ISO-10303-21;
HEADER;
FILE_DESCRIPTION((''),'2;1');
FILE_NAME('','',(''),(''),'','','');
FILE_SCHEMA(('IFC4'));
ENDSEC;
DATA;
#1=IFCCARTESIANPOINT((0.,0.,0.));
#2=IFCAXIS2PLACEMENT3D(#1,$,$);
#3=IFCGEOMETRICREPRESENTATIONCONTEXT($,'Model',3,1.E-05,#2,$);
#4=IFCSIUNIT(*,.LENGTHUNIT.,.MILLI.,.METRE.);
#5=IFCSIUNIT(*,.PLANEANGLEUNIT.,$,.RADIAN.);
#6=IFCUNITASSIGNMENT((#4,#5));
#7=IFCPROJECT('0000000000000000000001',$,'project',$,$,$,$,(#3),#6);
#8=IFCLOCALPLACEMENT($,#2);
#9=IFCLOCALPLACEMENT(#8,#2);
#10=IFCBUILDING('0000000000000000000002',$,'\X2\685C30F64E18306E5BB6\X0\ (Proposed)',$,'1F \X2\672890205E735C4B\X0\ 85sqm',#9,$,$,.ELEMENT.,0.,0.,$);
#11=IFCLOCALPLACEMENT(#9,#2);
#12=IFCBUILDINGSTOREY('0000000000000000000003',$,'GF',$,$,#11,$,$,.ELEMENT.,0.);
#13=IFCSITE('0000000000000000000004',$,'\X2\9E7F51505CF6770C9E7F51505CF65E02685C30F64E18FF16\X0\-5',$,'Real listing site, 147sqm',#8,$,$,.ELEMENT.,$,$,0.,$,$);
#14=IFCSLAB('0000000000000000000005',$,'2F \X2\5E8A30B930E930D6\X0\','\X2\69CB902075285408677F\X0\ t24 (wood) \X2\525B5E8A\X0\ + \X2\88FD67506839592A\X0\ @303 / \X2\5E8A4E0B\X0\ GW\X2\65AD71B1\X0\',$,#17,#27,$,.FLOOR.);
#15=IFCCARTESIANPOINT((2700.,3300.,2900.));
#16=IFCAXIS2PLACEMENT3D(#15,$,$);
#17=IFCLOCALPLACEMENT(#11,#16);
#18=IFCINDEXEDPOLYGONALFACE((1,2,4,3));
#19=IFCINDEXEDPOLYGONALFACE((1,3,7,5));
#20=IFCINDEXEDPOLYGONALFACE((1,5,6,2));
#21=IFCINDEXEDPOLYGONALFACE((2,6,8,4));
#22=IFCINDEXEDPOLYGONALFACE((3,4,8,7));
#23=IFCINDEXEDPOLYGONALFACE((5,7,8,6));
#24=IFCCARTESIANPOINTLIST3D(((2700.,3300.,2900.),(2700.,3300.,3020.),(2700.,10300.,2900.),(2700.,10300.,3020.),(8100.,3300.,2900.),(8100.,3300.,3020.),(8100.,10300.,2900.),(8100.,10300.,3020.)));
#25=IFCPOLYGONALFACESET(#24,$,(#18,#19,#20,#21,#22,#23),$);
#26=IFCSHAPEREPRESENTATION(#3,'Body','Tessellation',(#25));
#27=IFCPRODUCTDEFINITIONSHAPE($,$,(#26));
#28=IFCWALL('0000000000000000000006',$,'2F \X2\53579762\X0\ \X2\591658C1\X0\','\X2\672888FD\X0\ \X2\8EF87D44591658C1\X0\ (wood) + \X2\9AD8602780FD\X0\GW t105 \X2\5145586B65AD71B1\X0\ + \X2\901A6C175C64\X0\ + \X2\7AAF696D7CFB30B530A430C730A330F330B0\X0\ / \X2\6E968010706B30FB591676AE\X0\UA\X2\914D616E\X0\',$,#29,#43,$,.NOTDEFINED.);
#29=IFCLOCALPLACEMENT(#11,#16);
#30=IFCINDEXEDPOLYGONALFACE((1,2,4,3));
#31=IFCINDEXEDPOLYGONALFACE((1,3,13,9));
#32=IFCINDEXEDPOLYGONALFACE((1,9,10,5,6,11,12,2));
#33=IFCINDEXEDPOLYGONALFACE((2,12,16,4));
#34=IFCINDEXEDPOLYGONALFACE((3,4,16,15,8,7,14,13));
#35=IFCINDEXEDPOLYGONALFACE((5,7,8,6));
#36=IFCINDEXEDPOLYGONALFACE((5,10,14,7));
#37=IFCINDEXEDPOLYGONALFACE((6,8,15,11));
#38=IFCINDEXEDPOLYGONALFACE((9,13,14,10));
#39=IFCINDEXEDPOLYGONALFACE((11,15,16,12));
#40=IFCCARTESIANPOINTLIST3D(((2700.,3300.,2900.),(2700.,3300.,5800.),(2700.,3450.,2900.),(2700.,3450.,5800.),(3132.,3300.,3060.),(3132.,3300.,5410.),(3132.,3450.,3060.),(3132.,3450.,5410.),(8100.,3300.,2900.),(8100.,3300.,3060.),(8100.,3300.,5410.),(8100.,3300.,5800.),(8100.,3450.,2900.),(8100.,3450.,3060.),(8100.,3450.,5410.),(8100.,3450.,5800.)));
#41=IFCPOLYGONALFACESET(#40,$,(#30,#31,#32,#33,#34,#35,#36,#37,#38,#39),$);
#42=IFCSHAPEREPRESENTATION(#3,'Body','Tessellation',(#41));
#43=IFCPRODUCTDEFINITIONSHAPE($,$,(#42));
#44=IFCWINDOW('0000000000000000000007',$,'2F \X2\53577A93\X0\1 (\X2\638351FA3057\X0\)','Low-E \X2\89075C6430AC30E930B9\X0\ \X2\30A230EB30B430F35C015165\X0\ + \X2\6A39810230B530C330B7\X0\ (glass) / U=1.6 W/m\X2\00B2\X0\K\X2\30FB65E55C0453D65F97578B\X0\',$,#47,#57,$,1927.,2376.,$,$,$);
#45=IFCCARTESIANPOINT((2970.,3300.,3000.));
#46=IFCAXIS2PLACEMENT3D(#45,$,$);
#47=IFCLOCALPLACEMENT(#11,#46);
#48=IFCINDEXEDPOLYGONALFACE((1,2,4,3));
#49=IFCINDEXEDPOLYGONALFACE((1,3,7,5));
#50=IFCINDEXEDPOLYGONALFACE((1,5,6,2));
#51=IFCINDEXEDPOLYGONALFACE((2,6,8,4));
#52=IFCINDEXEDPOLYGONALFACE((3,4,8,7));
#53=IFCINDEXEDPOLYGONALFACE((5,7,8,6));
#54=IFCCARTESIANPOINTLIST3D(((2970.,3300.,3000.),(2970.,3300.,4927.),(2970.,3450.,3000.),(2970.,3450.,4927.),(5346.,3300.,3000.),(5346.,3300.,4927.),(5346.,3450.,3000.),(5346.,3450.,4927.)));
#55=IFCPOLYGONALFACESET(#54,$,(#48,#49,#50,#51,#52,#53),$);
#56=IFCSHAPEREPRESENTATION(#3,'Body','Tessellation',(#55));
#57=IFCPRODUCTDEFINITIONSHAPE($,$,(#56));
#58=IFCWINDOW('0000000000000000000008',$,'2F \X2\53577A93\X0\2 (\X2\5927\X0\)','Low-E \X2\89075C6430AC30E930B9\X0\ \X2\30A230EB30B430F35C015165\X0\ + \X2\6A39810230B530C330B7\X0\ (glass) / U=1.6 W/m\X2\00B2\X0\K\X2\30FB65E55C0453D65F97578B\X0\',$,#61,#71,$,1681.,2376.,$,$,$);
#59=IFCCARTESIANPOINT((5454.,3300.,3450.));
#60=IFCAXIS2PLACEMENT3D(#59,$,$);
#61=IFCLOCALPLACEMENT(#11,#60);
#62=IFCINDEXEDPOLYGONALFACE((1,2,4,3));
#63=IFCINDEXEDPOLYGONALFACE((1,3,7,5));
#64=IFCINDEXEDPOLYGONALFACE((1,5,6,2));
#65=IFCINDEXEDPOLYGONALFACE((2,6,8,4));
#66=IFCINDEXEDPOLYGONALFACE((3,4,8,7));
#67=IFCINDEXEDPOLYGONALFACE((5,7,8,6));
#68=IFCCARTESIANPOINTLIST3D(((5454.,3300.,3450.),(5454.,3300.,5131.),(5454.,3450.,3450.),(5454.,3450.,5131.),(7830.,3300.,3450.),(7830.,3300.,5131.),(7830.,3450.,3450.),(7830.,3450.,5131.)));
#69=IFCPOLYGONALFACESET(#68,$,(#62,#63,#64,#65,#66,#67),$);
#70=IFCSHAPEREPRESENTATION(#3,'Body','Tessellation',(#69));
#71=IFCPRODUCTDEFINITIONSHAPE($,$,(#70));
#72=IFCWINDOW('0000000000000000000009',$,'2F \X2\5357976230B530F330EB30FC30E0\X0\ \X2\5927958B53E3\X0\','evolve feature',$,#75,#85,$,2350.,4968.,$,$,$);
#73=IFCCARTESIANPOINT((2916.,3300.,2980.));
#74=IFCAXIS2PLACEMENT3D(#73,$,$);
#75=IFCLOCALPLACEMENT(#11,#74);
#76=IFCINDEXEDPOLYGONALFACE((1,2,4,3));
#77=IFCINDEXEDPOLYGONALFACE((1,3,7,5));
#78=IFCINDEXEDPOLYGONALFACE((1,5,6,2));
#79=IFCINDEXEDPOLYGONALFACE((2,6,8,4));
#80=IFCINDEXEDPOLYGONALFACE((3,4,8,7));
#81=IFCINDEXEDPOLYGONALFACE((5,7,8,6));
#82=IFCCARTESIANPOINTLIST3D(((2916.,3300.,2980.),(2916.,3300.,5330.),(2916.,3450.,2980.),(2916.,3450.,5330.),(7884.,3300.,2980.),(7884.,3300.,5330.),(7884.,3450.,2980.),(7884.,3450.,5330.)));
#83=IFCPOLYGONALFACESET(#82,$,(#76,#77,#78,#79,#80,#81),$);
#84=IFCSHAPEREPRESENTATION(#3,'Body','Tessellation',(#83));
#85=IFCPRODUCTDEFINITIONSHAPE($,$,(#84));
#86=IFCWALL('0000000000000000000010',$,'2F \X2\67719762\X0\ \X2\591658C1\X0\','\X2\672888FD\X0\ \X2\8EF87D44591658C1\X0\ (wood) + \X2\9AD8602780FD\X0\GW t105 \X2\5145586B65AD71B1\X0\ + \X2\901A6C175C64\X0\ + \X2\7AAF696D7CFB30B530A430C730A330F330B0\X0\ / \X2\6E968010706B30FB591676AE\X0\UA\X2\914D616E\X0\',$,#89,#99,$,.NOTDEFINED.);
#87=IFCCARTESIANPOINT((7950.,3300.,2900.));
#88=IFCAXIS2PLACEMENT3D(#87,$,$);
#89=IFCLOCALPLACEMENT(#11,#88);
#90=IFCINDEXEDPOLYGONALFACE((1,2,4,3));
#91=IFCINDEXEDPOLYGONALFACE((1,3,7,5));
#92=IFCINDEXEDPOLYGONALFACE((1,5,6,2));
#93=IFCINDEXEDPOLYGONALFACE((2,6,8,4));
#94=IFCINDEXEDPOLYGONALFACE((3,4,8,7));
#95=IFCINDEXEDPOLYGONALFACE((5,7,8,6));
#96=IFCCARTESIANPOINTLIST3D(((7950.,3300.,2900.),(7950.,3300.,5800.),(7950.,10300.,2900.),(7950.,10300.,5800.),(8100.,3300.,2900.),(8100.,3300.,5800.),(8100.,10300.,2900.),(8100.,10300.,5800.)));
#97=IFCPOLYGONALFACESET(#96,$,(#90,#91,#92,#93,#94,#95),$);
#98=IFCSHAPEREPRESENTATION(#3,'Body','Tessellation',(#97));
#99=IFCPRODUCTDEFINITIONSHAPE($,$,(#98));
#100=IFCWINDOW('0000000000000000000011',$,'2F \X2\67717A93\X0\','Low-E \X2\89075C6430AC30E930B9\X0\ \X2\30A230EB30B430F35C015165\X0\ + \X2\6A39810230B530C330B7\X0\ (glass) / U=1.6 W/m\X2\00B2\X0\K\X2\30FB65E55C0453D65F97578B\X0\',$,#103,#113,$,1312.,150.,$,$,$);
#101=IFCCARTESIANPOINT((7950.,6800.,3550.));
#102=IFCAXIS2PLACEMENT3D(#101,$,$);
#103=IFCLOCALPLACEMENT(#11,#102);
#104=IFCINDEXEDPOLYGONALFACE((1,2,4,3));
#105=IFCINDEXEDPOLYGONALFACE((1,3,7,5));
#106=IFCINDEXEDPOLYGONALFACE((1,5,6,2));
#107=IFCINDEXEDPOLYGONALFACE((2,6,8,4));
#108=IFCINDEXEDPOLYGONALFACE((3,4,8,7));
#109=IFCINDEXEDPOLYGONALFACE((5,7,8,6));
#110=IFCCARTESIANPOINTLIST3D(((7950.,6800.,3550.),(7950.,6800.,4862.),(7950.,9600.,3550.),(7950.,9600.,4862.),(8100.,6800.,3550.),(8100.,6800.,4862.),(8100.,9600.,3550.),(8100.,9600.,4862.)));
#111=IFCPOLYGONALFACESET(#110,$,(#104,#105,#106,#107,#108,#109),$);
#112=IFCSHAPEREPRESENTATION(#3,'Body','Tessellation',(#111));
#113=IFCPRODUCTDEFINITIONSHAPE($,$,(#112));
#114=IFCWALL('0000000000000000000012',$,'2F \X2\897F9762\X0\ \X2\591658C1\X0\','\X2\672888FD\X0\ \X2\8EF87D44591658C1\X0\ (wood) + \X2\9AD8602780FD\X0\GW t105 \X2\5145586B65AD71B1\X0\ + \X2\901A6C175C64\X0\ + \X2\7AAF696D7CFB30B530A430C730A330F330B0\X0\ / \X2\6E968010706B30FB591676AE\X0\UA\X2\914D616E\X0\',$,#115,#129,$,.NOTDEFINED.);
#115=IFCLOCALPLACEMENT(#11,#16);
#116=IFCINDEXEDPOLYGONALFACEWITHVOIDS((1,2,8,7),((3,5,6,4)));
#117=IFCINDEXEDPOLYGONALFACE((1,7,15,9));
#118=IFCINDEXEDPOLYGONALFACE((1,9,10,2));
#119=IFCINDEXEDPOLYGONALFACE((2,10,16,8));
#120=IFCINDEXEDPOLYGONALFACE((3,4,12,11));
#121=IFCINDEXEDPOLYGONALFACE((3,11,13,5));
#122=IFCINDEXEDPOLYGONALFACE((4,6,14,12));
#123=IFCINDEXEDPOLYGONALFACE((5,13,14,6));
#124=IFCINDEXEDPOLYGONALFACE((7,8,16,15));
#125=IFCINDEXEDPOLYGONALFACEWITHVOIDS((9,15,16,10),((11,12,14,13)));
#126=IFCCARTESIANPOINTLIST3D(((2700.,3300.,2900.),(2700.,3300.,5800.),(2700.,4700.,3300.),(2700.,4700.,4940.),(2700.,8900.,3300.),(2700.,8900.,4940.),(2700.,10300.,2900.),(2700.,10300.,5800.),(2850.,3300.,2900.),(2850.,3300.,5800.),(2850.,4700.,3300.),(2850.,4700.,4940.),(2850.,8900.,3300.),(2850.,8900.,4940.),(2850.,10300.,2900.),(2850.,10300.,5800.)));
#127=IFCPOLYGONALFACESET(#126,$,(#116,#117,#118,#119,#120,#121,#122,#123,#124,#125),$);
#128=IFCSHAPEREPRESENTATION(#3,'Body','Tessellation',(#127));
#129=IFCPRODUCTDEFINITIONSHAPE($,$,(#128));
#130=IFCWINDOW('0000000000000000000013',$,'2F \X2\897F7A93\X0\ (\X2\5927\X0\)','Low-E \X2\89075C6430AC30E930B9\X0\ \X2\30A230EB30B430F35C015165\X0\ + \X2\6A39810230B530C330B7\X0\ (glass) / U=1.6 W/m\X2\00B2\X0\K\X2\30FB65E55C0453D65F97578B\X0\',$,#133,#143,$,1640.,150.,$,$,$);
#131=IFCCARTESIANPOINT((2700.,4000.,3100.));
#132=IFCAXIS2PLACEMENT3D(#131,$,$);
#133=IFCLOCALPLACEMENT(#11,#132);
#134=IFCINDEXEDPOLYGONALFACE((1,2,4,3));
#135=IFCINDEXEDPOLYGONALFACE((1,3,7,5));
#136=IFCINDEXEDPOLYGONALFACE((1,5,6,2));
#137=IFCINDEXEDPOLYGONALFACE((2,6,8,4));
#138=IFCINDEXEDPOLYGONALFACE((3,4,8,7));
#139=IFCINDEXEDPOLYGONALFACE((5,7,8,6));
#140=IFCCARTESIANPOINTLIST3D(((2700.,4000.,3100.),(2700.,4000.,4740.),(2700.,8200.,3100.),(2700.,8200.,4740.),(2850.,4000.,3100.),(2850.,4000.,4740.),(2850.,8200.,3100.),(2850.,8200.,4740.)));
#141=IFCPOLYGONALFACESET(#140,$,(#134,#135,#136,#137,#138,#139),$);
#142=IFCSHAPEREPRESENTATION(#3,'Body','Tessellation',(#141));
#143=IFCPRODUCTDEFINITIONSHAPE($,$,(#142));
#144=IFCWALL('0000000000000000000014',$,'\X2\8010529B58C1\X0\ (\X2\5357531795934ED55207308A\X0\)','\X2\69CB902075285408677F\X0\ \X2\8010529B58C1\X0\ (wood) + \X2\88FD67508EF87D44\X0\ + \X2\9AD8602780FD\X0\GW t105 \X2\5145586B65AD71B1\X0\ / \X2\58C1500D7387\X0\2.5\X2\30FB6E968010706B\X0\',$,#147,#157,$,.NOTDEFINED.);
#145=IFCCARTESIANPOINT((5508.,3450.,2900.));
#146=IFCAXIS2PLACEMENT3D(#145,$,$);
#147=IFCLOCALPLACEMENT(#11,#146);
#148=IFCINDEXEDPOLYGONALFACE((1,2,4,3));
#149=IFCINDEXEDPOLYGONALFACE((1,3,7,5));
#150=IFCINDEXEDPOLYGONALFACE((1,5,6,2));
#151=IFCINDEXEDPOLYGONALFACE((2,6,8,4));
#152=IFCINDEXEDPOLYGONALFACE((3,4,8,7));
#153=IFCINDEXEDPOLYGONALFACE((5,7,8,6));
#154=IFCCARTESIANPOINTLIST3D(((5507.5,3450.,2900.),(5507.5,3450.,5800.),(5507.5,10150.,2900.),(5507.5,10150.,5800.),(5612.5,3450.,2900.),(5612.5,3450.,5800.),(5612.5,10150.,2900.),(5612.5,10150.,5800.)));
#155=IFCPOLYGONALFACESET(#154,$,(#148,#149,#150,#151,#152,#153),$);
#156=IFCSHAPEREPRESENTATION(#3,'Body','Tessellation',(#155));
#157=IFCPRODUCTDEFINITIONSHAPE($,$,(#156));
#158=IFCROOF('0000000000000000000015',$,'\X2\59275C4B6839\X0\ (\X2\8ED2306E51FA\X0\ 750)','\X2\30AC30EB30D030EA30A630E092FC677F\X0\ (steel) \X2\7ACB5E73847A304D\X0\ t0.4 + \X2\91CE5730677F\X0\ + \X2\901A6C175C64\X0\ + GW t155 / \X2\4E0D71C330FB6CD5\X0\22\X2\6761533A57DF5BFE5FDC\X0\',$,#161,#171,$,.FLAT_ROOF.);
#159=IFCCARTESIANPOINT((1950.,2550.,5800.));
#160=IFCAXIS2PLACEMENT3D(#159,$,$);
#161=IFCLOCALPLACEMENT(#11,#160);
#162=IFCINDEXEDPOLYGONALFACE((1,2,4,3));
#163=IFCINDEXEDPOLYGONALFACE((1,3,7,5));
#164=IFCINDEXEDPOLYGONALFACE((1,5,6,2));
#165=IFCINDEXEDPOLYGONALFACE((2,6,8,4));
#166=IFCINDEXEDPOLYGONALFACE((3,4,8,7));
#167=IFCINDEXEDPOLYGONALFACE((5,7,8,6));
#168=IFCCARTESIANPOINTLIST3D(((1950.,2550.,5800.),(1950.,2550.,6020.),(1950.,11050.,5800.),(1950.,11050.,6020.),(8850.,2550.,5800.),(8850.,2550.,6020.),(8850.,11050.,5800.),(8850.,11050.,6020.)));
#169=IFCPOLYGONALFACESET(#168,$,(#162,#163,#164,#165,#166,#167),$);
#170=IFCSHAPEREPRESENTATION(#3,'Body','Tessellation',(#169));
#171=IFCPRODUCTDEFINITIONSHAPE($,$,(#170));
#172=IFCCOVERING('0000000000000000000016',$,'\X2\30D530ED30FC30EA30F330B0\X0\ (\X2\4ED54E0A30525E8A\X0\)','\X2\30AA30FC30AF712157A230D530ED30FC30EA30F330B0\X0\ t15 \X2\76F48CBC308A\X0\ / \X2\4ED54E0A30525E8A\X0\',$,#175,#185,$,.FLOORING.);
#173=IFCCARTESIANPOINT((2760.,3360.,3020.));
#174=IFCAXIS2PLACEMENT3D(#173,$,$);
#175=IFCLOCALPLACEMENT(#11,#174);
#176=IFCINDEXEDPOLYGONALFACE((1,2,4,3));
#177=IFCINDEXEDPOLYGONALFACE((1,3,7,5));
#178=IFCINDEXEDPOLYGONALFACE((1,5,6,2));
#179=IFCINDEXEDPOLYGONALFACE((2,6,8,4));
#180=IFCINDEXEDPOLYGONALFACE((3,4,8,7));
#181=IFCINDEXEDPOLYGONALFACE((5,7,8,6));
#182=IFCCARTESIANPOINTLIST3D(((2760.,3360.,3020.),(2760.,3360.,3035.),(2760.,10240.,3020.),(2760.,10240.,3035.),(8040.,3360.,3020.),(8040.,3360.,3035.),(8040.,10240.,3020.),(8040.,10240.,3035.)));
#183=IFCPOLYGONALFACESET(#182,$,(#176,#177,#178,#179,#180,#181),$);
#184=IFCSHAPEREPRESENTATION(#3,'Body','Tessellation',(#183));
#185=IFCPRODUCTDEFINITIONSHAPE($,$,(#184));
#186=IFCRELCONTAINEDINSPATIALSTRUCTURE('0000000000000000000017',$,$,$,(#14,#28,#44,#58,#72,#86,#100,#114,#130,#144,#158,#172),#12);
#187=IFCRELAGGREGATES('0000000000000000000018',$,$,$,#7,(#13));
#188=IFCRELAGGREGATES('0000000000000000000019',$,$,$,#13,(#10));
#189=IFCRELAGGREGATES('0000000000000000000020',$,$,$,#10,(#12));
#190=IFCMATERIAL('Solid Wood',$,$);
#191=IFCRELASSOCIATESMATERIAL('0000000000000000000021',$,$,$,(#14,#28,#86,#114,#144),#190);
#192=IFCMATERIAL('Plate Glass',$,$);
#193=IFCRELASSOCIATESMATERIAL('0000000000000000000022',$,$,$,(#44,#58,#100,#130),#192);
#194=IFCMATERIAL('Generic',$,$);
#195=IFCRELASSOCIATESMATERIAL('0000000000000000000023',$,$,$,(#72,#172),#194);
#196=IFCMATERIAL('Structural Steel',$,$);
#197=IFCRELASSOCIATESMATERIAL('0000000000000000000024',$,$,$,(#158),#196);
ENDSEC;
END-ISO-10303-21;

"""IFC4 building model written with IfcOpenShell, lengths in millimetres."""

from ifc_helpers import new_model, si_unit, frame, frame_2d, origin, place, context, project, spatial, rectangle, extrude, material, element, fill, save


model = new_model("IFC4")

# Units and contexts
model_context = context("Model", 3, precision=1e-05, world=origin())
ifc_project = project(units=[si_unit("LENGTHUNIT", "METRE", prefix="MILLI"), si_unit("PLANEANGLEUNIT", "RADIAN")], contexts=[model_context])

# Site, building, storey
site_placement = place(None, origin())
site = spatial("IfcSite", under=ifc_project, at=site_placement, Name="鹿児島県鹿児島市桜ヶ丘６-5", ObjectType="Real listing site, 147sqm", CompositionType="ELEMENT", RefElevation=0.0)
building_placement = place(site_placement, origin())
building = spatial("IfcBuilding", under=site, at=building_placement, Name="桜ヶ丘の家 (Proposed)", ObjectType="1F 木造平屋 85sqm", CompositionType="ELEMENT", ElevationOfRefHeight=0.0, ElevationOfTerrain=0.0)
storey_placement = place(building_placement, origin())
storey = spatial("IfcBuildingStorey", under=building, at=storey_placement, Name="GF", CompositionType="ELEMENT", Elevation=0.0)

# Slab
ifc_material_1 = material(Name="Solid Wood")
slab_placement = place(storey_placement, frame((2700.0, 3300.0, 2900.0)))
element("IfcSlab", 1, at=slab_placement, inside=storey, material=ifc_material_1, Name="2F 床スラブ", Description="構造用合板 t24 (wood) 剛床 + 製材根太 @303 / 床下 GW断熱", PredefinedType="FLOOR", context=model_context, shape_type="SweptSolid", body=[
    extrude(rectangle(XDim=5400.0, YDim=7000.0, at=frame_2d((2700.0, 3500.0))), frame((2700.0, 3300.0, 2900.0)), (0.0, 0.0, 1.0), 120.0),
])

# Wall, openings, windows
wall_1_placement = place(storey_placement, frame((2700.0, 3300.0, 2900.0)))
wall_1 = element("IfcWall", 2, at=wall_1_placement, inside=storey, material=ifc_material_1, Name="2F 南面 外壁", Description="木製 軸組外壁 (wood) + 高性能GW t105 充填断熱 + 通気層 + 窯業系サイディング / 準耐火・外皮UA配慮", PredefinedType="NOTDEFINED", context=model_context, shape_type="SweptSolid", body=[
    extrude(rectangle(XDim=5400.0, YDim=150.0, at=frame_2d((2700.0, 75.0))), frame((2700.0, 3300.0, 2900.0)), (0.0, 0.0, 1.0), 2900.0),
])
opening_1_placement = place(storey_placement, frame((2970.0, 3300.0, 3000.0)))
opening_1 = element("IfcOpeningElement", 3, at=opening_1_placement, cuts=wall_1, PredefinedType="NOTDEFINED", context=model_context, shape_type="SweptSolid", body=[
    extrude(rectangle(XDim=2376.0, YDim=150.0, at=frame_2d((1188.0, 75.0))), frame((2970.0, 3300.0, 3000.0)), (0.0, 0.0, 1.0), 1927.0),
])
opening_2_placement = place(storey_placement, frame((5454.0, 3300.0, 3450.0)))
opening_2 = element("IfcOpeningElement", 4, at=opening_2_placement, cuts=wall_1, PredefinedType="NOTDEFINED", context=model_context, shape_type="SweptSolid", body=[
    extrude(rectangle(XDim=2376.0, YDim=150.0, at=frame_2d((1188.0, 75.0))), frame((5454.0, 3300.0, 3450.0)), (0.0, 0.0, 1.0), 1681.0),
])
opening_3_placement = place(storey_placement, frame((2916.0, 3300.0, 2980.0)))
opening_3 = element("IfcOpeningElement", 5, at=opening_3_placement, cuts=wall_1, PredefinedType="NOTDEFINED", context=model_context, shape_type="SweptSolid", body=[
    extrude(rectangle(XDim=4968.0, YDim=150.0, at=frame_2d((2484.0, 75.0))), frame((2916.0, 3300.0, 2980.0)), (0.0, 0.0, 1.0), 2350.0),
])
ifc_material_2 = material(Name="Plate Glass")
window_1_placement = place(storey_placement, frame((2970.0, 3300.0, 3000.0)))
window_1 = element("IfcWindow", 6, at=window_1_placement, inside=storey, material=ifc_material_2, Name="2F 南窓1 (掃出し)", Description="Low-E 複層ガラス アルゴン封入 + 樹脂サッシ (glass) / U=1.6 W/m²K・日射取得型", OverallHeight=1927.0, OverallWidth=2376.0, context=model_context, shape_type="SweptSolid", body=[
    extrude(rectangle(XDim=2376.0, YDim=150.0, at=frame_2d((1188.0, 75.0))), frame((2970.0, 3300.0, 3000.0)), (0.0, 0.0, 1.0), 1927.0),
])
fill(opening_1, window_1)
window_2_placement = place(storey_placement, frame((5454.0, 3300.0, 3450.0)))
window_2 = element("IfcWindow", 7, at=window_2_placement, inside=storey, material=ifc_material_2, Name="2F 南窓2 (大)", Description="Low-E 複層ガラス アルゴン封入 + 樹脂サッシ (glass) / U=1.6 W/m²K・日射取得型", OverallHeight=1681.0, OverallWidth=2376.0, context=model_context, shape_type="SweptSolid", body=[
    extrude(rectangle(XDim=2376.0, YDim=150.0, at=frame_2d((1188.0, 75.0))), frame((5454.0, 3300.0, 3450.0)), (0.0, 0.0, 1.0), 1681.0),
])
fill(opening_2, window_2)
ifc_material_3 = material(Name="Generic")
window_3_placement = place(storey_placement, frame((2916.0, 3300.0, 2980.0)))
window_3 = element("IfcWindow", 8, at=window_3_placement, inside=storey, material=ifc_material_3, Name="2F 南面サンルーム 大開口", Description="evolve feature", OverallHeight=2350.0, OverallWidth=4968.0, context=model_context, shape_type="SweptSolid", body=[
    extrude(rectangle(XDim=4968.0, YDim=150.0, at=frame_2d((2484.0, 75.0))), frame((2916.0, 3300.0, 2980.0)), (0.0, 0.0, 1.0), 2350.0),
])
fill(opening_3, window_3)

# Walls, openings, windows
wall_2_placement = place(storey_placement, frame((7950.0, 3300.0, 2900.0)))
wall_2 = element("IfcWall", 9, at=wall_2_placement, inside=storey, material=ifc_material_1, Name="2F 東面 外壁", Description="木製 軸組外壁 (wood) + 高性能GW t105 充填断熱 + 通気層 + 窯業系サイディング / 準耐火・外皮UA配慮", PredefinedType="NOTDEFINED", context=model_context, shape_type="SweptSolid", body=[
    extrude(rectangle(XDim=150.0, YDim=7000.0, at=frame_2d((75.0, 3500.0))), frame((7950.0, 3300.0, 2900.0)), (0.0, 0.0, 1.0), 2900.0),
])
opening_4_placement = place(storey_placement, frame((7950.0, 6800.0, 3550.0)))
opening_4 = element("IfcOpeningElement", 10, at=opening_4_placement, cuts=wall_2, PredefinedType="NOTDEFINED", context=model_context, shape_type="SweptSolid", body=[
    extrude(rectangle(XDim=150.0, YDim=2800.0, at=frame_2d((75.0, 1400.0))), frame((7950.0, 6800.0, 3550.0)), (0.0, 0.0, 1.0), 1312.0),
])
window_4_placement = place(storey_placement, frame((7950.0, 6800.0, 3550.0)))
window_4 = element("IfcWindow", 11, at=window_4_placement, inside=storey, material=ifc_material_2, Name="2F 東窓", Description="Low-E 複層ガラス アルゴン封入 + 樹脂サッシ (glass) / U=1.6 W/m²K・日射取得型", OverallHeight=1312.0, OverallWidth=150.0, context=model_context, shape_type="SweptSolid", body=[
    extrude(rectangle(XDim=150.0, YDim=2800.0, at=frame_2d((75.0, 1400.0))), frame((7950.0, 6800.0, 3550.0)), (0.0, 0.0, 1.0), 1312.0),
])
fill(opening_4, window_4)
wall_3_placement = place(storey_placement, frame((2700.0, 3300.0, 2900.0)))
wall_3 = element("IfcWall", 12, at=wall_3_placement, inside=storey, material=ifc_material_1, Name="2F 西面 外壁", Description="木製 軸組外壁 (wood) + 高性能GW t105 充填断熱 + 通気層 + 窯業系サイディング / 準耐火・外皮UA配慮", PredefinedType="NOTDEFINED", context=model_context, shape_type="SweptSolid", body=[
    extrude(rectangle(XDim=150.0, YDim=7000.0, at=frame_2d((75.0, 3500.0))), frame((2700.0, 3300.0, 2900.0)), (0.0, 0.0, 1.0), 2900.0),
])
opening_5_placement = place(storey_placement, frame((2700.0, 4000.0, 3100.0)))
opening_5 = element("IfcOpeningElement", 13, at=opening_5_placement, cuts=wall_3, PredefinedType="NOTDEFINED", context=model_context, shape_type="SweptSolid", body=[
    extrude(rectangle(XDim=150.0, YDim=4200.0, at=frame_2d((75.0, 2100.0))), frame((2700.0, 4000.0, 3100.0)), (0.0, 0.0, 1.0), 1640.0),
])
window_5_placement = place(storey_placement, frame((2700.0, 4000.0, 3100.0)))
window_5 = element("IfcWindow", 14, at=window_5_placement, inside=storey, material=ifc_material_2, Name="2F 西窓 (大)", Description="Low-E 複層ガラス アルゴン封入 + 樹脂サッシ (glass) / U=1.6 W/m²K・日射取得型", OverallHeight=1640.0, OverallWidth=150.0, context=model_context, shape_type="SweptSolid", body=[
    extrude(rectangle(XDim=150.0, YDim=4200.0, at=frame_2d((75.0, 2100.0))), frame((2700.0, 4000.0, 3100.0)), (0.0, 0.0, 1.0), 1640.0),
])
fill(opening_5, window_5)

# Wall
wall_4_placement = place(storey_placement, frame((5508.0, 3450.0, 2900.0)))
element("IfcWall", 15, at=wall_4_placement, inside=storey, material=ifc_material_1, Name="耐力壁 (南北間仕切り)", Description="構造用合板 耐力壁 (wood) + 製材軸組 + 高性能GW t105 充填断熱 / 壁倍率2.5・準耐火", PredefinedType="NOTDEFINED", context=model_context, shape_type="SweptSolid", body=[
    extrude(rectangle(XDim=105.0, YDim=6700.0, at=frame_2d((52.0, 3350.0))), frame((5508.0, 3450.0, 2900.0)), (0.0, 0.0, 1.0), 2900.0),
])

# Roof
ifc_material_4 = material(Name="Structural Steel")
roof_placement = place(storey_placement, frame((1950.0, 2550.0, 5800.0)))
element("IfcRoof", 16, at=roof_placement, inside=storey, material=ifc_material_4, Name="大屋根 (軒の出 750)", Description="ガルバリウム鋼板 (steel) 立平葺き t0.4 + 野地板 + 通気層 + GW t155 / 不燃・法22条区域対応", PredefinedType="FLAT_ROOF", context=model_context, shape_type="SweptSolid", body=[
    extrude(rectangle(XDim=6900.0, YDim=8500.0, at=frame_2d((3450.0, 4250.0))), frame((1950.0, 2550.0, 5800.0)), (0.0, 0.0, 1.0), 220.0),
])

# Covering
covering_placement = place(storey_placement, frame((2760.0, 3360.0, 3020.0)))
element("IfcCovering", 17, at=covering_placement, inside=storey, material=ifc_material_3, Name="フローリング (仕上げ床)", Description="オーク無垢フローリング t15 直貼り / 仕上げ床", PredefinedType="FLOORING", context=model_context, shape_type="SweptSolid", body=[
    extrude(rectangle(XDim=5280.0, YDim=6880.0, at=frame_2d((2640.0, 3440.0))), frame((2760.0, 3360.0, 3020.0)), (0.0, 0.0, 1.0), 15.0),
])

save(model, "model.ifc")
